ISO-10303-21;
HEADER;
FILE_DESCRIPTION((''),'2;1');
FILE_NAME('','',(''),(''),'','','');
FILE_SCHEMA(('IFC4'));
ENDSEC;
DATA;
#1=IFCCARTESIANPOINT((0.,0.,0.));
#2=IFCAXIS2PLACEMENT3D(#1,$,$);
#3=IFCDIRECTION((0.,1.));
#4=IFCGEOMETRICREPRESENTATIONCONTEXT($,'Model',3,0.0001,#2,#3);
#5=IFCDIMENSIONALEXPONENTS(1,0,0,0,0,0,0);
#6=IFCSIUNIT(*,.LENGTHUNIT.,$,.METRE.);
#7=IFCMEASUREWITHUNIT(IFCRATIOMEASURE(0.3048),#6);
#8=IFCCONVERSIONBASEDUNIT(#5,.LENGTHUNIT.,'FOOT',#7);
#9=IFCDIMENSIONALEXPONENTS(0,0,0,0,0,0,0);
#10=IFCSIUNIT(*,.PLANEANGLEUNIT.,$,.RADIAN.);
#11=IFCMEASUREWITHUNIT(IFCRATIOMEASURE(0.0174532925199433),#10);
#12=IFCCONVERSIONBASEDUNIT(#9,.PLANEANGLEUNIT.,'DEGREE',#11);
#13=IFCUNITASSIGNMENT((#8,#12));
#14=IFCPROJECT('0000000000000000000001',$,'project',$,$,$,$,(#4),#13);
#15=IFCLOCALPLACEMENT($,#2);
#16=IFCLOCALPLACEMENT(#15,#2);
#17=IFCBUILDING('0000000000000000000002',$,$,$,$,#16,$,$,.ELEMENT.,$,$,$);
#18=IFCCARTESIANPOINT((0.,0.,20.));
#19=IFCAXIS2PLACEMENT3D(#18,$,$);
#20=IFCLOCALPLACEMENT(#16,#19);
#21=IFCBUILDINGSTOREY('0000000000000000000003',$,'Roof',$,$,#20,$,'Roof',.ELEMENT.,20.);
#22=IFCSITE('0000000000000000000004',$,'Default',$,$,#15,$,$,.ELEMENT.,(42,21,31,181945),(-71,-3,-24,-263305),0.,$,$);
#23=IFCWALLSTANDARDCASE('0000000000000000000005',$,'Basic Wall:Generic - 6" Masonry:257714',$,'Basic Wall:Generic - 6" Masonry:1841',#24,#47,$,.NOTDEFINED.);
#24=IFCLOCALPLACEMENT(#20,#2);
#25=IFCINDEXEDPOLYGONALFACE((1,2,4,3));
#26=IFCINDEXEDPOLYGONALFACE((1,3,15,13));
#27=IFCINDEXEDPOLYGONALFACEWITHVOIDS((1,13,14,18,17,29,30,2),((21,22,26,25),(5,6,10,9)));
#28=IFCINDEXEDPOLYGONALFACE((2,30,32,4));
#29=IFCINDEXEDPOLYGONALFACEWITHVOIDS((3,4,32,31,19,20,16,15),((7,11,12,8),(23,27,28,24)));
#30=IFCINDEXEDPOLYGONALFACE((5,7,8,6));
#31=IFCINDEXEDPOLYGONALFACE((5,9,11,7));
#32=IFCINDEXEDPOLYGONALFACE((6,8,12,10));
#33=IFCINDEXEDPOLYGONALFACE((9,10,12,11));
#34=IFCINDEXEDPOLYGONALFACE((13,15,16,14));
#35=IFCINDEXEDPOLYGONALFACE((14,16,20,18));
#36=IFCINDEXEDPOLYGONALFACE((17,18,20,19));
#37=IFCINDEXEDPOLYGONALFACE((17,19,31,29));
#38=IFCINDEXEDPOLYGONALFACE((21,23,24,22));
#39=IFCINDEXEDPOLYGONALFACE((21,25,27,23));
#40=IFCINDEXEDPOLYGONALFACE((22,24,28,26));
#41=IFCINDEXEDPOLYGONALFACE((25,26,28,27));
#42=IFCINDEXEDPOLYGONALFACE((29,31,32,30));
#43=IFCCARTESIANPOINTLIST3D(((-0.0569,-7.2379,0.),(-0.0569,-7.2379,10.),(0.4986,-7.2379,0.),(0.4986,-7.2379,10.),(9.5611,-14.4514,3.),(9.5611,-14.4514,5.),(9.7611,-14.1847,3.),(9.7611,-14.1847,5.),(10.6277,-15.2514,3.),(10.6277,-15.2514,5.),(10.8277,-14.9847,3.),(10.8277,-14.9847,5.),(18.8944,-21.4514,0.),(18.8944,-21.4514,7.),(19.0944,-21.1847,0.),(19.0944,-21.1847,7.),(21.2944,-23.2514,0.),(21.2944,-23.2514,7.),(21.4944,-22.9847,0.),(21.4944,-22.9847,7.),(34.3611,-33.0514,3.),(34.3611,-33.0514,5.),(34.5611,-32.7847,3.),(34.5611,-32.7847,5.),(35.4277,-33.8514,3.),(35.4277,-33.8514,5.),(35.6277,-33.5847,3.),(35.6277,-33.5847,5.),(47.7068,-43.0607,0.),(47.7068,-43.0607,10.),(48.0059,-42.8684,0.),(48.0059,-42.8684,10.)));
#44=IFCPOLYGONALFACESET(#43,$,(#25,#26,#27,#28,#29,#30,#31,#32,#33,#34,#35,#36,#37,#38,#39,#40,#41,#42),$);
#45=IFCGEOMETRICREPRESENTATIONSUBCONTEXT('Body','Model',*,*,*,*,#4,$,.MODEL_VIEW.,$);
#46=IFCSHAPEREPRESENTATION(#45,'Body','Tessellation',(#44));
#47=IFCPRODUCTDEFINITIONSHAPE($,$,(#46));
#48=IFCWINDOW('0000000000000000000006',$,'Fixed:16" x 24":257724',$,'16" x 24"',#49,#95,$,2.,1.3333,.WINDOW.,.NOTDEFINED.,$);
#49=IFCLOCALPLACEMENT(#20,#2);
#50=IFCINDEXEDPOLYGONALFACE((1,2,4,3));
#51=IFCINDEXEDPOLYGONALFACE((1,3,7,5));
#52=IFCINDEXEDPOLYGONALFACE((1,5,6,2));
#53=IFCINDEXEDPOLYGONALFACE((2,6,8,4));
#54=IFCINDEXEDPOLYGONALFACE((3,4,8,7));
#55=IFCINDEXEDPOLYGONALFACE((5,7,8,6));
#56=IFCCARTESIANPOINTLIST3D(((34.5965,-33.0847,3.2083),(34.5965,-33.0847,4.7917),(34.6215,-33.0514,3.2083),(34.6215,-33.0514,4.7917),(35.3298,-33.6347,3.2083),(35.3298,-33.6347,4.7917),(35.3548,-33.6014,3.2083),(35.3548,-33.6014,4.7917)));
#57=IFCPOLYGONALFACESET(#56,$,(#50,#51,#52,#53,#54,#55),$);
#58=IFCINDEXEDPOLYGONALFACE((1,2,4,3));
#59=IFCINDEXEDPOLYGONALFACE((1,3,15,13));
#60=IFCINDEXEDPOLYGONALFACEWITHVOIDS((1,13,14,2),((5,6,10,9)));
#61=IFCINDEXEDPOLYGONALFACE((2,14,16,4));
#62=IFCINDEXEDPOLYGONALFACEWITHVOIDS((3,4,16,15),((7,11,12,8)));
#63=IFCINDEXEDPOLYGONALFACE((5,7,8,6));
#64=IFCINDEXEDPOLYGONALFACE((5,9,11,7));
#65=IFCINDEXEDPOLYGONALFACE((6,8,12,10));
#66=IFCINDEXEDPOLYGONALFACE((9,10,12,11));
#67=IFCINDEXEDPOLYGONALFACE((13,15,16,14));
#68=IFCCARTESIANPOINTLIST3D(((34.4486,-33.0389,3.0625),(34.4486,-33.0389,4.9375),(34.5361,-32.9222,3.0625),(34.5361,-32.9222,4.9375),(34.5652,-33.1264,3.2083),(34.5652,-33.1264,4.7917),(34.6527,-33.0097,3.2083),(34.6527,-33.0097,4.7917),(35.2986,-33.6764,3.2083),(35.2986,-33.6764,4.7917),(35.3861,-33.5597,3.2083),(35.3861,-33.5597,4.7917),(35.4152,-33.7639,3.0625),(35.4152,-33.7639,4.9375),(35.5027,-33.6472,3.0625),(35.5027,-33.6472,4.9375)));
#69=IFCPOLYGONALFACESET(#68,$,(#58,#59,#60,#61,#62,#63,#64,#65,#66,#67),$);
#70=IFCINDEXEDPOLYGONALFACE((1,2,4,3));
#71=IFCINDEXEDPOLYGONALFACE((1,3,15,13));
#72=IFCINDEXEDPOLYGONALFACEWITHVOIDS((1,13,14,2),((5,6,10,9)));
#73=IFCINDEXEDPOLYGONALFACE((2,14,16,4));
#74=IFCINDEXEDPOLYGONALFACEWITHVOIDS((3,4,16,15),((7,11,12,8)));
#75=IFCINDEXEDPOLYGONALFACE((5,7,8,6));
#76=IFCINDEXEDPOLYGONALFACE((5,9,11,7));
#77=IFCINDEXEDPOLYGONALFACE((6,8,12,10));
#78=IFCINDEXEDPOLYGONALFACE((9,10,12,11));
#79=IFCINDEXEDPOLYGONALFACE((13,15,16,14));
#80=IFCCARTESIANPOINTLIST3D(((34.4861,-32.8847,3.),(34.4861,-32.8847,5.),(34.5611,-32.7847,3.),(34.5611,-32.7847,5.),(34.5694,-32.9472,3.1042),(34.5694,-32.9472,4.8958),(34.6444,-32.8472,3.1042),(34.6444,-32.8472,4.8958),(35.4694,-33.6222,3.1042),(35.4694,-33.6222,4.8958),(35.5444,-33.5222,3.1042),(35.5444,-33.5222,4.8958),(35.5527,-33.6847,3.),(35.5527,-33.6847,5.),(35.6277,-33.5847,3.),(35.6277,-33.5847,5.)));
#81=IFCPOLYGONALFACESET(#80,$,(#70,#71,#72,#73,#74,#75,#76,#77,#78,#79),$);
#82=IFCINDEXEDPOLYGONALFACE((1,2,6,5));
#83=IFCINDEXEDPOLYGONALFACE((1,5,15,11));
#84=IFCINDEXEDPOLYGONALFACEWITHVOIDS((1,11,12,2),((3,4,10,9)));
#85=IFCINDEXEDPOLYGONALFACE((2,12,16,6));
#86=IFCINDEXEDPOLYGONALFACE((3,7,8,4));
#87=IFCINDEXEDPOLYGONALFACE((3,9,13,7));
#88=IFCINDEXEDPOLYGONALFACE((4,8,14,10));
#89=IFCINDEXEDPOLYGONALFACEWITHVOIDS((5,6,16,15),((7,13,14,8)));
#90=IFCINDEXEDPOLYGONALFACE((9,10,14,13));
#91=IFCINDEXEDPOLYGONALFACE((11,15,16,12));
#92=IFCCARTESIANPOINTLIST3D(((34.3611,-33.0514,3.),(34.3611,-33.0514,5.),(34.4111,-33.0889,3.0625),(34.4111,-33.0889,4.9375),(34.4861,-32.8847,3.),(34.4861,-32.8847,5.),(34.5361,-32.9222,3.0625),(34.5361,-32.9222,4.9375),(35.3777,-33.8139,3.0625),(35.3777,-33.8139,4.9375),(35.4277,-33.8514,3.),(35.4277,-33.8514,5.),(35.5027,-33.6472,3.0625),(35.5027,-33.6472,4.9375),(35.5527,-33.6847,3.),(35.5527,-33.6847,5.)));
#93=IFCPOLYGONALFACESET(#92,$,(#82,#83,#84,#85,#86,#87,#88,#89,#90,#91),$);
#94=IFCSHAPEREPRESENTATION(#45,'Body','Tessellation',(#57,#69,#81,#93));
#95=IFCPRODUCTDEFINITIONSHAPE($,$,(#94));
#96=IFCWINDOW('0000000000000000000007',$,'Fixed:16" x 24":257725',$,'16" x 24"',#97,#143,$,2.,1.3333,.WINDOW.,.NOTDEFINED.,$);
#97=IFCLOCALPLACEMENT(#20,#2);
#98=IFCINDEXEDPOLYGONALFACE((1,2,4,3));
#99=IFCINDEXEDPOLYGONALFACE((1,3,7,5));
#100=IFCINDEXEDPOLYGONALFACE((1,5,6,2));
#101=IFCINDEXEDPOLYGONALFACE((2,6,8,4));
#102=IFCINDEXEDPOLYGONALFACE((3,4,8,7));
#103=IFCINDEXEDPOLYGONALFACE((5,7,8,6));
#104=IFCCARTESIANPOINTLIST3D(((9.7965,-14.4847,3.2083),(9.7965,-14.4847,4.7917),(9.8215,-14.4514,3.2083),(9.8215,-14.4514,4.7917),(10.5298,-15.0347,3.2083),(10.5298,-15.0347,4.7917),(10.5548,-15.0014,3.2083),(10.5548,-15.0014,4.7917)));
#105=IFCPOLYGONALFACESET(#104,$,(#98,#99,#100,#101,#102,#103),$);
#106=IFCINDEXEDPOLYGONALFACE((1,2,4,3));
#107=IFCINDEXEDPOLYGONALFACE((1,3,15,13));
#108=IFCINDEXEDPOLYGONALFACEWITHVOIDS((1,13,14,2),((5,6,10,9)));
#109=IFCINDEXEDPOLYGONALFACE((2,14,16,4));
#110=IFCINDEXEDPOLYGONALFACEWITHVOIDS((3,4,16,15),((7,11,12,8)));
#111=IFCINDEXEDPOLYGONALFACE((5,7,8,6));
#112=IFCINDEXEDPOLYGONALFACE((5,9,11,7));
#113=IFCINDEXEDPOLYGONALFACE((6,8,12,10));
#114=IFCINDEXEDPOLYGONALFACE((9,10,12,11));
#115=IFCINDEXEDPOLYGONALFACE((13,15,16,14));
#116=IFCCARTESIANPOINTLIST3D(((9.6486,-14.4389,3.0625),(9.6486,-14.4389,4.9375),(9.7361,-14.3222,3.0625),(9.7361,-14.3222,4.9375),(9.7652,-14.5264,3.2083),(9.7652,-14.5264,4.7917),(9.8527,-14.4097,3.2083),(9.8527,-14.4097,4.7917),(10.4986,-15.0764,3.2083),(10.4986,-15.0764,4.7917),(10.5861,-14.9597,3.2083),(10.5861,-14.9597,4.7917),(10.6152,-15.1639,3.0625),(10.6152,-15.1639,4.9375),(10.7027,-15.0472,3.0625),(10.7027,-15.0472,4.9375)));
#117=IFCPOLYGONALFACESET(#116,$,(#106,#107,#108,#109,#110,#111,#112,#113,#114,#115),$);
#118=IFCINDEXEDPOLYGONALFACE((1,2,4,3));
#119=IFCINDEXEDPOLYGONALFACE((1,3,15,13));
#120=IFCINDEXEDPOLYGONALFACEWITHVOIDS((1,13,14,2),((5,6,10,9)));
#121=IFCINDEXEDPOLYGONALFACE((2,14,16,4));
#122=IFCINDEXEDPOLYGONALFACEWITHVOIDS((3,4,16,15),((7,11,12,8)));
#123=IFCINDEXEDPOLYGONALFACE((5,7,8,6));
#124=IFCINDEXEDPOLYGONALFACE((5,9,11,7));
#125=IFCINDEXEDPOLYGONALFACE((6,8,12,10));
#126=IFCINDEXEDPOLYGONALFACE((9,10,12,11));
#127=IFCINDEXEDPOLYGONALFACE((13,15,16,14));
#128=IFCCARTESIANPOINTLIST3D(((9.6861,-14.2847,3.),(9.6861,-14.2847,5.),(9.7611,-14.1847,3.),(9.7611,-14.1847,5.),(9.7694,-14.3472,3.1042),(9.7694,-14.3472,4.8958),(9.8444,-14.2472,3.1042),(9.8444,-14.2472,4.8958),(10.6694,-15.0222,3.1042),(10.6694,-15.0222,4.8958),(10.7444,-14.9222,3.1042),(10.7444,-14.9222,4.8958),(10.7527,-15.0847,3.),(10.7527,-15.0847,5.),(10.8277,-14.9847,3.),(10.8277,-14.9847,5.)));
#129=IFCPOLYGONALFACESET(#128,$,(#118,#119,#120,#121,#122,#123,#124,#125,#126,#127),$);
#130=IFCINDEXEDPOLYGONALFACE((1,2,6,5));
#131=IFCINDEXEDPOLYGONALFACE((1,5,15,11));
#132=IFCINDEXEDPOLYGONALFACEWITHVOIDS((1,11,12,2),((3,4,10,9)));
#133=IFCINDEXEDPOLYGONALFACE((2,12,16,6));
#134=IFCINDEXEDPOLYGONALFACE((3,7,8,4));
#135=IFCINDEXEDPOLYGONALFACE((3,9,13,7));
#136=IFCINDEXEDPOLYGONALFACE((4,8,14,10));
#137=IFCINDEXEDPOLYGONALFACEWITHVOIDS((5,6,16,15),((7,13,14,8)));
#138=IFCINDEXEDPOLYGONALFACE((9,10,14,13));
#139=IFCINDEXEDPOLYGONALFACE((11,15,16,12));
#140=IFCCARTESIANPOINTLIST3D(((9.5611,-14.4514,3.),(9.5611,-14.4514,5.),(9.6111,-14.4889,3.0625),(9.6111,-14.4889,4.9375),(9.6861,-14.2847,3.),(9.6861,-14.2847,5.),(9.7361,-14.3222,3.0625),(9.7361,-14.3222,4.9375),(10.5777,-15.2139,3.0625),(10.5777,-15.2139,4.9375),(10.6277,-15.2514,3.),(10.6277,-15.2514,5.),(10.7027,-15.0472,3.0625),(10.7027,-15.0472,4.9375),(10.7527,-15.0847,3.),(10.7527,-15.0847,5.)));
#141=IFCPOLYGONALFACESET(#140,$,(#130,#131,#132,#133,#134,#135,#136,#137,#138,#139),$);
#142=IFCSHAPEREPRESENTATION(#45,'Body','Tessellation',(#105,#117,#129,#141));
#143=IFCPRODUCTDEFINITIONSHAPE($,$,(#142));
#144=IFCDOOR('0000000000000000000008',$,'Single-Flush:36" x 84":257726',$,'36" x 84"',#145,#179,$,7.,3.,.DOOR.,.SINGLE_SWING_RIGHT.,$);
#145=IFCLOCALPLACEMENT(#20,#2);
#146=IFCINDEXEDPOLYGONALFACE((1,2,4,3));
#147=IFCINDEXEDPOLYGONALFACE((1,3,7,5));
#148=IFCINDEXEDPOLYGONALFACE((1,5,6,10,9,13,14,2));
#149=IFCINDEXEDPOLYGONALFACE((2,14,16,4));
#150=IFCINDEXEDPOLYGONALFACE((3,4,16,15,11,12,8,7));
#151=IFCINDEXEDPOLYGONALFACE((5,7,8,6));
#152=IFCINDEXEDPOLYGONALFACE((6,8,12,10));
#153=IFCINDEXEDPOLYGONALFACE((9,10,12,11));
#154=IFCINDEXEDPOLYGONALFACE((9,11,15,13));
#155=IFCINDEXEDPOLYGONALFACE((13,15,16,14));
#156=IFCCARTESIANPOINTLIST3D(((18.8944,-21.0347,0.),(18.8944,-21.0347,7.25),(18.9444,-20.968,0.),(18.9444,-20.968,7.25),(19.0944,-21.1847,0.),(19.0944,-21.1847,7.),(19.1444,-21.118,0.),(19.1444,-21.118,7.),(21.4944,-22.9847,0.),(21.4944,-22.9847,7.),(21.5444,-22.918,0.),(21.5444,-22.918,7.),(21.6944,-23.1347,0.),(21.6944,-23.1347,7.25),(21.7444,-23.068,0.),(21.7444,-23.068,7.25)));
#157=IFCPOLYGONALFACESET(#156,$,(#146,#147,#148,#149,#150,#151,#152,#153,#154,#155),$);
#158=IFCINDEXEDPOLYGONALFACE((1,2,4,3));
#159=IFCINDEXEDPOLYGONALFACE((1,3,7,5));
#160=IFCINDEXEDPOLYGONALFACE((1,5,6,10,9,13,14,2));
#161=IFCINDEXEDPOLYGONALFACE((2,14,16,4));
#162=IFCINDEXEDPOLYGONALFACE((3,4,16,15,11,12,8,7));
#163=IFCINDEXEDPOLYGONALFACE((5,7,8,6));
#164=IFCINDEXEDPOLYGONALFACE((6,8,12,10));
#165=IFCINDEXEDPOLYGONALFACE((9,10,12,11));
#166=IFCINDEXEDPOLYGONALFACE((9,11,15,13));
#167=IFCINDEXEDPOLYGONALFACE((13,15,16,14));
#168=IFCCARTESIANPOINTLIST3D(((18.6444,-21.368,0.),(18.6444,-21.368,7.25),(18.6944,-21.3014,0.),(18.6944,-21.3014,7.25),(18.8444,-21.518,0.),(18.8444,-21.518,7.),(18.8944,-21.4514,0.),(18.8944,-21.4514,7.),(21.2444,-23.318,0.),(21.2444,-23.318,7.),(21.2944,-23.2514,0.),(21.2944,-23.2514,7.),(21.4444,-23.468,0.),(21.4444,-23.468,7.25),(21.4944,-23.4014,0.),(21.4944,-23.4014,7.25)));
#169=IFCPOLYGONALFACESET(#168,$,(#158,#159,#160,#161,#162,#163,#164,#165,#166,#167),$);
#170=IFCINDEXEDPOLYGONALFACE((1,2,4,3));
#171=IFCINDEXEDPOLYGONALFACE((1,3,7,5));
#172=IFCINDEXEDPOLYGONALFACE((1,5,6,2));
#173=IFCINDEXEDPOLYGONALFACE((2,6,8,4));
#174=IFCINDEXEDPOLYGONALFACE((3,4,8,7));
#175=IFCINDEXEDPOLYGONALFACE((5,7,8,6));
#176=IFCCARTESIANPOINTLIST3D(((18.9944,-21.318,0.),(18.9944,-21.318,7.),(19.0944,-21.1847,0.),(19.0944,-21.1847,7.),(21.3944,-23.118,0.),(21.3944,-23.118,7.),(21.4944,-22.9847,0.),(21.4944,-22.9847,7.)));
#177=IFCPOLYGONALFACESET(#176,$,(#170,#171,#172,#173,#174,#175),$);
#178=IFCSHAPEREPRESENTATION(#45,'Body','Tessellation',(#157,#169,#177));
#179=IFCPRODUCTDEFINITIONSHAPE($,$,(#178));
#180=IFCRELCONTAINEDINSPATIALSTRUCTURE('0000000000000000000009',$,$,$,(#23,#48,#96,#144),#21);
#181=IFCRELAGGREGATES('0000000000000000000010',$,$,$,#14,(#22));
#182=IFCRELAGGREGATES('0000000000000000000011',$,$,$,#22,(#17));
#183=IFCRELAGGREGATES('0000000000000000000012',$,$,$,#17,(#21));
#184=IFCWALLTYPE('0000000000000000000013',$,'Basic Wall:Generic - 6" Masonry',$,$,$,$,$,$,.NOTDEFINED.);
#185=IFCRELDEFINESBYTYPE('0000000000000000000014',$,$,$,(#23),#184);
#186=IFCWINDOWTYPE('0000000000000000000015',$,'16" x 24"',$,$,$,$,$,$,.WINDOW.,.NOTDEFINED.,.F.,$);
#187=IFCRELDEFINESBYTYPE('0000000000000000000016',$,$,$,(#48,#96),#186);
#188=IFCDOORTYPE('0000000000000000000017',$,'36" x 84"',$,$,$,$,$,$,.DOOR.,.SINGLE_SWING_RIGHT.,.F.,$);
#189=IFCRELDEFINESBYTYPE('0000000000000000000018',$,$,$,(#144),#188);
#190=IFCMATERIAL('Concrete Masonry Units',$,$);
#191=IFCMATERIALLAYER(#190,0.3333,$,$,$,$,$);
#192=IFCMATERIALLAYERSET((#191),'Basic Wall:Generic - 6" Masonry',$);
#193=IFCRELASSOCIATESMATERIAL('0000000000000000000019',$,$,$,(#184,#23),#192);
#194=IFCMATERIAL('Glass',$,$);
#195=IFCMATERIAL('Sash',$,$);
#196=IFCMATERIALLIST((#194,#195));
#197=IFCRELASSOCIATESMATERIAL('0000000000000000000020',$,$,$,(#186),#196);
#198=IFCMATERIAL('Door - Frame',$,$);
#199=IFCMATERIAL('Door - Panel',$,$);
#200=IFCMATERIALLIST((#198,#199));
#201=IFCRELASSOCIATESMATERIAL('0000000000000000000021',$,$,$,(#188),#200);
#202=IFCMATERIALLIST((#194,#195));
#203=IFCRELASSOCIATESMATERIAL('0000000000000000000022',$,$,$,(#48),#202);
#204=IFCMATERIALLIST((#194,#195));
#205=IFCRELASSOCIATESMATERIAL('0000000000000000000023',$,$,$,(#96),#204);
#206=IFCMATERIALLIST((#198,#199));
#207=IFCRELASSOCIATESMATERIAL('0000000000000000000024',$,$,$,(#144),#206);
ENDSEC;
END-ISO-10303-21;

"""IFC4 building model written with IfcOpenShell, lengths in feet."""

from ifc_helpers import new_model, entity, si_unit, converted_unit, direction, frame, frame_2d, origin, origin_2d_with_axis, place, context, subcontext, project, spatial, polyline, rectangle, outline, extrude, source, transform, mapped, material, material_list, layer, layer_set, layer_usage, type_object, type_shapes, element, fill, save


model = new_model("IFC4")

# Units and contexts
model_context = context("Model", 3, precision=0.0001, world=origin(), true_north=direction((0.0, 1.0)))
body_context = subcontext(model_context, "Body", "Model", "MODEL_VIEW")
ifc_project = project(units=[converted_unit("LENGTHUNIT", "FOOT", entity("IfcRatioMeasure", 0.3048), si_unit("LENGTHUNIT", "METRE"), dimensions=[1, 0, 0, 0, 0, 0, 0]), converted_unit("PLANEANGLEUNIT", "DEGREE", entity("IfcRatioMeasure", 0.0174532925199433), si_unit("PLANEANGLEUNIT", "RADIAN"), dimensions=[0, 0, 0, 0, 0, 0, 0])], contexts=[model_context])

# Site, building, storey
site_placement = place(None, origin())
site = spatial("IfcSite", under=ifc_project, at=site_placement, Name="Default", CompositionType="ELEMENT", RefLatitude=(42, 21, 31, 181945), RefLongitude=(-71, -3, -24, -263305), RefElevation=0.0)
building_placement = place(site_placement, origin())
building = spatial("IfcBuilding", under=site, at=building_placement, CompositionType="ELEMENT")
storey_placement = place(building_placement, frame((0.0, 0.0, 20.0)))
storey = spatial("IfcBuildingStorey", under=building, at=storey_placement, Name="Roof", LongName="Roof", CompositionType="ELEMENT", Elevation=20.0)

# Shared definitions
ifc_material_1 = material(Name="Concrete Masonry Units")
ifc_layer = layer(ifc_material_1, 0.3333)
ifc_layer_set = layer_set([ifc_layer], Name="Basic Wall:Generic - 6\" Masonry")
wall_type = type_object("IfcWallType", Name="Basic Wall:Generic - 6\" Masonry", PredefinedType="NOTDEFINED", material=ifc_layer_set)
ifc_material_2 = material(Name="Glass")
ifc_material_3 = material(Name="Sash")
ifc_material_list_1 = material_list([ifc_material_2, ifc_material_3])
window_type = type_object("IfcWindowType", Name="16\" x 24\"", ParameterTakesPrecedence=False, PartitioningType="NOTDEFINED", PredefinedType="WINDOW", material=ifc_material_list_1)
shared_shape_1 = source(origin(), body_context, "Body", "SweptSolid", [
    extrude(rectangle(XDim=0.0417, YDim=0.9167, at=origin_2d_with_axis()), frame((0.6667, 0.1979, 0.2083), z_axis=(0.0, 0.0, 1.0), x_axis=(0.0, 1.0, 0.0)), (0.0, 0.0, 1.0), 1.5833),
    extrude(outline(polyline([(-0.6042, -0.9375), (0.6042, -0.9375), (0.6042, 0.9375), (-0.6042, 0.9375), (-0.6042, -0.9375)]), holes=[polyline([(-0.4583, -0.7917), (-0.4583, 0.7917), (0.4583, 0.7917), (0.4583, -0.7917), (-0.4583, -0.7917)])]), frame((0.6667, 0.125, 1.0), z_axis=(0.0, 1.0, 0.0), x_axis=(1.0, 0.0, 0.0)), (0.0, 0.0, 1.0), 0.1458),
    extrude(outline(polyline([(-0.6667, -1.0), (0.6667, -1.0), (0.6667, 1.0), (-0.6667, 1.0), (-0.6667, -1.0)]), holes=[polyline([(-0.5625, -0.8958), (-0.5625, 0.8958), (0.5625, 0.8958), (0.5625, -0.8958), (-0.5625, -0.8958)])]), frame((0.6667, 0.0, 1.0), z_axis=(0.0, 1.0, 0.0), x_axis=(1.0, 0.0, 0.0)), (0.0, 0.0, 1.0), 0.125),
    extrude(outline(polyline([(-1.0, -0.6667), (1.0, -0.6667), (1.0, 0.6667), (-1.0, 0.6667), (-1.0, -0.6667)]), holes=[polyline([(-0.9375, -0.6042), (-0.9375, 0.6042), (0.9375, 0.6042), (0.9375, -0.6042), (-0.9375, -0.6042)])]), frame((0.6667, 0.125, 1.0), z_axis=(0.0, 1.0, 0.0), x_axis=(0.0, 0.0, -1.0)), (0.0, 0.0, 1.0), 0.2083),
])
type_shapes(window_type, [shared_shape_1])
ifc_material_4 = material(Name="Door - Frame")
ifc_material_5 = material(Name="Door - Panel")
ifc_material_list_2 = material_list([ifc_material_4, ifc_material_5])
door_type = type_object("IfcDoorType", Name="36\" x 84\"", OperationType="SINGLE_SWING_RIGHT", ParameterTakesPrecedence=False, PredefinedType="DOOR", material=ifc_material_list_2)
shared_shape_2 = source(origin(), body_context, "Body", "SweptSolid", [
    extrude(outline(polyline([(-1.75, -3.6875), (1.75, -3.6875), (1.75, 3.5625), (1.5, 3.5625), (1.5, -3.4375), (-1.5, -3.4375), (-1.5, 3.5625), (-1.75, 3.5625), (-1.75, -3.6875)])), frame((1.5, 0.3333, 3.5625), z_axis=(0.0, 1.0, 0.0), x_axis=(1.0, 0.0, 0.0)), (0.0, 0.0, 1.0), 0.0833),
    extrude(outline(polyline([(-3.6875, -1.75), (3.5625, -1.75), (3.5625, -1.5), (-3.4375, -1.5), (-3.4375, 1.5), (3.5625, 1.5), (3.5625, 1.75), (-3.6875, 1.75), (-3.6875, -1.75)])), frame((1.5, -0.0833, 3.5625), z_axis=(0.0, 1.0, 0.0), x_axis=(0.0, 0.0, -1.0)), (0.0, 0.0, 1.0), 0.0833),
    extrude(rectangle(XDim=0.1667, YDim=3.0, at=frame_2d((0.0, 0.0), x_axis=(1.0, 0.0))), frame((1.5, 0.25, 0.0), z_axis=(0.0, 0.0, 1.0), x_axis=(0.0, 1.0, 0.0)), (0.0, 0.0, 1.0), 7.0),
])
type_shapes(door_type, [shared_shape_2])

# Wall, openings, windows, door
ifc_layer_usage_1 = layer_usage(ifc_layer_set, "AXIS2", "NEGATIVE", 0.1667)
wall_1_placement = place(storey_placement, frame((47.9059, -43.0017, 0.0), z_axis=(0.0, 0.0, 1.0), x_axis=(-0.8, 0.6, 0.0)))
wall_1 = element("IfcWallStandardCase", 1, at=wall_1_placement, inside=storey, type_object=wall_type, material=ifc_layer_usage_1, Name="Basic Wall:Generic - 6\" Masonry:257714", ObjectType="Basic Wall:Generic - 6\" Masonry:1841", PredefinedType="NOTDEFINED", context=body_context, shape_type="SweptSolid", body=[
    extrude(outline(polyline([(0.0, -0.1667), (59.3842, -0.1667), (59.8286, 0.1667), (0.1239, 0.1667), (0.0, -0.1667)])), origin(), (0.0, 0.0, 1.0), 10.0),
])
opening_1_placement = place(wall_1_placement, frame((36.1394, 0.1667, 0.0)))
opening_1 = element("IfcOpeningElement", 2, at=opening_1_placement, cuts=wall_1, ObjectType="Opening", PredefinedType="OPENING", context=body_context, shape_type="SweptSolid", body=[
    extrude(rectangle(XDim=3.0, YDim=7.0, at=frame_2d((3.5, 1.5), x_axis=(0.0, 1.0))), frame((0.0, 0.0, 0.0), z_axis=(0.0, -1.0, 0.0), x_axis=(0.0, 0.0, 1.0)), (0.0, 0.0, 1.0), 0.3333),
])
opening_2_placement = place(wall_1_placement, frame((15.4728, -0.1667, 3.0)))
opening_2 = element("IfcOpeningElement", 3, at=opening_2_placement, cuts=wall_1, ObjectType="Opening", PredefinedType="OPENING", context=body_context, shape_type="SweptSolid", body=[
    extrude(rectangle(XDim=2.0, YDim=1.3333, at=frame_2d((1.0, 0.6667), x_axis=(-1.0, 0.0))), frame((0.0, 0.0, 0.0), z_axis=(0.0, 1.0, 0.0), x_axis=(0.0, 0.0, 1.0)), (0.0, 0.0, 1.0), 0.3333),
])
opening_3_placement = place(wall_1_placement, frame((46.4728, -0.1667, 3.0)))
opening_3 = element("IfcOpeningElement", 4, at=opening_3_placement, cuts=wall_1, ObjectType="Opening", PredefinedType="OPENING", context=body_context, shape_type="SweptSolid", body=[
    extrude(rectangle(XDim=2.0, YDim=1.3333, at=frame_2d((1.0, 0.6667), x_axis=(-1.0, 0.0))), frame((0.0, 0.0, 0.0), z_axis=(0.0, 1.0, 0.0), x_axis=(0.0, 0.0, 1.0)), (0.0, 0.0, 1.0), 0.3333),
])
ifc_material_list_3 = material_list([ifc_material_2, ifc_material_3])
window_1_placement = place(opening_2_placement, origin())
window_1 = element("IfcWindow", 5, at=window_1_placement, inside=storey, type_object=window_type, material=ifc_material_list_3, Name="Fixed:16\" x 24\":257724", ObjectType="16\" x 24\"", OverallHeight=2.0, OverallWidth=1.3333, PartitioningType="NOTDEFINED", PredefinedType="WINDOW", context=body_context, shape_type="MappedRepresentation", body=[
    mapped(shared_shape_1, transform((0.0, 0.0, 0.0), scale=1.0)),
])
fill(opening_2, window_1)
ifc_material_list_4 = material_list([ifc_material_2, ifc_material_3])
window_2_placement = place(opening_3_placement, origin())
window_2 = element("IfcWindow", 6, at=window_2_placement, inside=storey, type_object=window_type, material=ifc_material_list_4, Name="Fixed:16\" x 24\":257725", ObjectType="16\" x 24\"", OverallHeight=2.0, OverallWidth=1.3333, PartitioningType="NOTDEFINED", PredefinedType="WINDOW", context=body_context, shape_type="MappedRepresentation", body=[
    mapped(shared_shape_1, transform((0.0, 0.0, 0.0), scale=1.0)),
])
fill(opening_3, window_2)
ifc_material_list_5 = material_list([ifc_material_4, ifc_material_5])
door_1_placement = place(opening_1_placement, frame((0.0, 0.0, 0.0), z_axis=(0.0, 0.0, 1.0), x_axis=(-1.0, 0.0, 0.0)))
door_1 = element("IfcDoor", 7, at=door_1_placement, inside=storey, type_object=door_type, material=ifc_material_list_5, Name="Single-Flush:36\" x 84\":257726", ObjectType="36\" x 84\"", OperationType="SINGLE_SWING_RIGHT", OverallHeight=7.0, OverallWidth=3.0, PredefinedType="DOOR", context=body_context, shape_type="MappedRepresentation", body=[
    mapped(shared_shape_2, transform((0.0, 0.0, 0.0), scale=1.0)),
])
fill(opening_1, door_1)

save(model, "model.ifc")
